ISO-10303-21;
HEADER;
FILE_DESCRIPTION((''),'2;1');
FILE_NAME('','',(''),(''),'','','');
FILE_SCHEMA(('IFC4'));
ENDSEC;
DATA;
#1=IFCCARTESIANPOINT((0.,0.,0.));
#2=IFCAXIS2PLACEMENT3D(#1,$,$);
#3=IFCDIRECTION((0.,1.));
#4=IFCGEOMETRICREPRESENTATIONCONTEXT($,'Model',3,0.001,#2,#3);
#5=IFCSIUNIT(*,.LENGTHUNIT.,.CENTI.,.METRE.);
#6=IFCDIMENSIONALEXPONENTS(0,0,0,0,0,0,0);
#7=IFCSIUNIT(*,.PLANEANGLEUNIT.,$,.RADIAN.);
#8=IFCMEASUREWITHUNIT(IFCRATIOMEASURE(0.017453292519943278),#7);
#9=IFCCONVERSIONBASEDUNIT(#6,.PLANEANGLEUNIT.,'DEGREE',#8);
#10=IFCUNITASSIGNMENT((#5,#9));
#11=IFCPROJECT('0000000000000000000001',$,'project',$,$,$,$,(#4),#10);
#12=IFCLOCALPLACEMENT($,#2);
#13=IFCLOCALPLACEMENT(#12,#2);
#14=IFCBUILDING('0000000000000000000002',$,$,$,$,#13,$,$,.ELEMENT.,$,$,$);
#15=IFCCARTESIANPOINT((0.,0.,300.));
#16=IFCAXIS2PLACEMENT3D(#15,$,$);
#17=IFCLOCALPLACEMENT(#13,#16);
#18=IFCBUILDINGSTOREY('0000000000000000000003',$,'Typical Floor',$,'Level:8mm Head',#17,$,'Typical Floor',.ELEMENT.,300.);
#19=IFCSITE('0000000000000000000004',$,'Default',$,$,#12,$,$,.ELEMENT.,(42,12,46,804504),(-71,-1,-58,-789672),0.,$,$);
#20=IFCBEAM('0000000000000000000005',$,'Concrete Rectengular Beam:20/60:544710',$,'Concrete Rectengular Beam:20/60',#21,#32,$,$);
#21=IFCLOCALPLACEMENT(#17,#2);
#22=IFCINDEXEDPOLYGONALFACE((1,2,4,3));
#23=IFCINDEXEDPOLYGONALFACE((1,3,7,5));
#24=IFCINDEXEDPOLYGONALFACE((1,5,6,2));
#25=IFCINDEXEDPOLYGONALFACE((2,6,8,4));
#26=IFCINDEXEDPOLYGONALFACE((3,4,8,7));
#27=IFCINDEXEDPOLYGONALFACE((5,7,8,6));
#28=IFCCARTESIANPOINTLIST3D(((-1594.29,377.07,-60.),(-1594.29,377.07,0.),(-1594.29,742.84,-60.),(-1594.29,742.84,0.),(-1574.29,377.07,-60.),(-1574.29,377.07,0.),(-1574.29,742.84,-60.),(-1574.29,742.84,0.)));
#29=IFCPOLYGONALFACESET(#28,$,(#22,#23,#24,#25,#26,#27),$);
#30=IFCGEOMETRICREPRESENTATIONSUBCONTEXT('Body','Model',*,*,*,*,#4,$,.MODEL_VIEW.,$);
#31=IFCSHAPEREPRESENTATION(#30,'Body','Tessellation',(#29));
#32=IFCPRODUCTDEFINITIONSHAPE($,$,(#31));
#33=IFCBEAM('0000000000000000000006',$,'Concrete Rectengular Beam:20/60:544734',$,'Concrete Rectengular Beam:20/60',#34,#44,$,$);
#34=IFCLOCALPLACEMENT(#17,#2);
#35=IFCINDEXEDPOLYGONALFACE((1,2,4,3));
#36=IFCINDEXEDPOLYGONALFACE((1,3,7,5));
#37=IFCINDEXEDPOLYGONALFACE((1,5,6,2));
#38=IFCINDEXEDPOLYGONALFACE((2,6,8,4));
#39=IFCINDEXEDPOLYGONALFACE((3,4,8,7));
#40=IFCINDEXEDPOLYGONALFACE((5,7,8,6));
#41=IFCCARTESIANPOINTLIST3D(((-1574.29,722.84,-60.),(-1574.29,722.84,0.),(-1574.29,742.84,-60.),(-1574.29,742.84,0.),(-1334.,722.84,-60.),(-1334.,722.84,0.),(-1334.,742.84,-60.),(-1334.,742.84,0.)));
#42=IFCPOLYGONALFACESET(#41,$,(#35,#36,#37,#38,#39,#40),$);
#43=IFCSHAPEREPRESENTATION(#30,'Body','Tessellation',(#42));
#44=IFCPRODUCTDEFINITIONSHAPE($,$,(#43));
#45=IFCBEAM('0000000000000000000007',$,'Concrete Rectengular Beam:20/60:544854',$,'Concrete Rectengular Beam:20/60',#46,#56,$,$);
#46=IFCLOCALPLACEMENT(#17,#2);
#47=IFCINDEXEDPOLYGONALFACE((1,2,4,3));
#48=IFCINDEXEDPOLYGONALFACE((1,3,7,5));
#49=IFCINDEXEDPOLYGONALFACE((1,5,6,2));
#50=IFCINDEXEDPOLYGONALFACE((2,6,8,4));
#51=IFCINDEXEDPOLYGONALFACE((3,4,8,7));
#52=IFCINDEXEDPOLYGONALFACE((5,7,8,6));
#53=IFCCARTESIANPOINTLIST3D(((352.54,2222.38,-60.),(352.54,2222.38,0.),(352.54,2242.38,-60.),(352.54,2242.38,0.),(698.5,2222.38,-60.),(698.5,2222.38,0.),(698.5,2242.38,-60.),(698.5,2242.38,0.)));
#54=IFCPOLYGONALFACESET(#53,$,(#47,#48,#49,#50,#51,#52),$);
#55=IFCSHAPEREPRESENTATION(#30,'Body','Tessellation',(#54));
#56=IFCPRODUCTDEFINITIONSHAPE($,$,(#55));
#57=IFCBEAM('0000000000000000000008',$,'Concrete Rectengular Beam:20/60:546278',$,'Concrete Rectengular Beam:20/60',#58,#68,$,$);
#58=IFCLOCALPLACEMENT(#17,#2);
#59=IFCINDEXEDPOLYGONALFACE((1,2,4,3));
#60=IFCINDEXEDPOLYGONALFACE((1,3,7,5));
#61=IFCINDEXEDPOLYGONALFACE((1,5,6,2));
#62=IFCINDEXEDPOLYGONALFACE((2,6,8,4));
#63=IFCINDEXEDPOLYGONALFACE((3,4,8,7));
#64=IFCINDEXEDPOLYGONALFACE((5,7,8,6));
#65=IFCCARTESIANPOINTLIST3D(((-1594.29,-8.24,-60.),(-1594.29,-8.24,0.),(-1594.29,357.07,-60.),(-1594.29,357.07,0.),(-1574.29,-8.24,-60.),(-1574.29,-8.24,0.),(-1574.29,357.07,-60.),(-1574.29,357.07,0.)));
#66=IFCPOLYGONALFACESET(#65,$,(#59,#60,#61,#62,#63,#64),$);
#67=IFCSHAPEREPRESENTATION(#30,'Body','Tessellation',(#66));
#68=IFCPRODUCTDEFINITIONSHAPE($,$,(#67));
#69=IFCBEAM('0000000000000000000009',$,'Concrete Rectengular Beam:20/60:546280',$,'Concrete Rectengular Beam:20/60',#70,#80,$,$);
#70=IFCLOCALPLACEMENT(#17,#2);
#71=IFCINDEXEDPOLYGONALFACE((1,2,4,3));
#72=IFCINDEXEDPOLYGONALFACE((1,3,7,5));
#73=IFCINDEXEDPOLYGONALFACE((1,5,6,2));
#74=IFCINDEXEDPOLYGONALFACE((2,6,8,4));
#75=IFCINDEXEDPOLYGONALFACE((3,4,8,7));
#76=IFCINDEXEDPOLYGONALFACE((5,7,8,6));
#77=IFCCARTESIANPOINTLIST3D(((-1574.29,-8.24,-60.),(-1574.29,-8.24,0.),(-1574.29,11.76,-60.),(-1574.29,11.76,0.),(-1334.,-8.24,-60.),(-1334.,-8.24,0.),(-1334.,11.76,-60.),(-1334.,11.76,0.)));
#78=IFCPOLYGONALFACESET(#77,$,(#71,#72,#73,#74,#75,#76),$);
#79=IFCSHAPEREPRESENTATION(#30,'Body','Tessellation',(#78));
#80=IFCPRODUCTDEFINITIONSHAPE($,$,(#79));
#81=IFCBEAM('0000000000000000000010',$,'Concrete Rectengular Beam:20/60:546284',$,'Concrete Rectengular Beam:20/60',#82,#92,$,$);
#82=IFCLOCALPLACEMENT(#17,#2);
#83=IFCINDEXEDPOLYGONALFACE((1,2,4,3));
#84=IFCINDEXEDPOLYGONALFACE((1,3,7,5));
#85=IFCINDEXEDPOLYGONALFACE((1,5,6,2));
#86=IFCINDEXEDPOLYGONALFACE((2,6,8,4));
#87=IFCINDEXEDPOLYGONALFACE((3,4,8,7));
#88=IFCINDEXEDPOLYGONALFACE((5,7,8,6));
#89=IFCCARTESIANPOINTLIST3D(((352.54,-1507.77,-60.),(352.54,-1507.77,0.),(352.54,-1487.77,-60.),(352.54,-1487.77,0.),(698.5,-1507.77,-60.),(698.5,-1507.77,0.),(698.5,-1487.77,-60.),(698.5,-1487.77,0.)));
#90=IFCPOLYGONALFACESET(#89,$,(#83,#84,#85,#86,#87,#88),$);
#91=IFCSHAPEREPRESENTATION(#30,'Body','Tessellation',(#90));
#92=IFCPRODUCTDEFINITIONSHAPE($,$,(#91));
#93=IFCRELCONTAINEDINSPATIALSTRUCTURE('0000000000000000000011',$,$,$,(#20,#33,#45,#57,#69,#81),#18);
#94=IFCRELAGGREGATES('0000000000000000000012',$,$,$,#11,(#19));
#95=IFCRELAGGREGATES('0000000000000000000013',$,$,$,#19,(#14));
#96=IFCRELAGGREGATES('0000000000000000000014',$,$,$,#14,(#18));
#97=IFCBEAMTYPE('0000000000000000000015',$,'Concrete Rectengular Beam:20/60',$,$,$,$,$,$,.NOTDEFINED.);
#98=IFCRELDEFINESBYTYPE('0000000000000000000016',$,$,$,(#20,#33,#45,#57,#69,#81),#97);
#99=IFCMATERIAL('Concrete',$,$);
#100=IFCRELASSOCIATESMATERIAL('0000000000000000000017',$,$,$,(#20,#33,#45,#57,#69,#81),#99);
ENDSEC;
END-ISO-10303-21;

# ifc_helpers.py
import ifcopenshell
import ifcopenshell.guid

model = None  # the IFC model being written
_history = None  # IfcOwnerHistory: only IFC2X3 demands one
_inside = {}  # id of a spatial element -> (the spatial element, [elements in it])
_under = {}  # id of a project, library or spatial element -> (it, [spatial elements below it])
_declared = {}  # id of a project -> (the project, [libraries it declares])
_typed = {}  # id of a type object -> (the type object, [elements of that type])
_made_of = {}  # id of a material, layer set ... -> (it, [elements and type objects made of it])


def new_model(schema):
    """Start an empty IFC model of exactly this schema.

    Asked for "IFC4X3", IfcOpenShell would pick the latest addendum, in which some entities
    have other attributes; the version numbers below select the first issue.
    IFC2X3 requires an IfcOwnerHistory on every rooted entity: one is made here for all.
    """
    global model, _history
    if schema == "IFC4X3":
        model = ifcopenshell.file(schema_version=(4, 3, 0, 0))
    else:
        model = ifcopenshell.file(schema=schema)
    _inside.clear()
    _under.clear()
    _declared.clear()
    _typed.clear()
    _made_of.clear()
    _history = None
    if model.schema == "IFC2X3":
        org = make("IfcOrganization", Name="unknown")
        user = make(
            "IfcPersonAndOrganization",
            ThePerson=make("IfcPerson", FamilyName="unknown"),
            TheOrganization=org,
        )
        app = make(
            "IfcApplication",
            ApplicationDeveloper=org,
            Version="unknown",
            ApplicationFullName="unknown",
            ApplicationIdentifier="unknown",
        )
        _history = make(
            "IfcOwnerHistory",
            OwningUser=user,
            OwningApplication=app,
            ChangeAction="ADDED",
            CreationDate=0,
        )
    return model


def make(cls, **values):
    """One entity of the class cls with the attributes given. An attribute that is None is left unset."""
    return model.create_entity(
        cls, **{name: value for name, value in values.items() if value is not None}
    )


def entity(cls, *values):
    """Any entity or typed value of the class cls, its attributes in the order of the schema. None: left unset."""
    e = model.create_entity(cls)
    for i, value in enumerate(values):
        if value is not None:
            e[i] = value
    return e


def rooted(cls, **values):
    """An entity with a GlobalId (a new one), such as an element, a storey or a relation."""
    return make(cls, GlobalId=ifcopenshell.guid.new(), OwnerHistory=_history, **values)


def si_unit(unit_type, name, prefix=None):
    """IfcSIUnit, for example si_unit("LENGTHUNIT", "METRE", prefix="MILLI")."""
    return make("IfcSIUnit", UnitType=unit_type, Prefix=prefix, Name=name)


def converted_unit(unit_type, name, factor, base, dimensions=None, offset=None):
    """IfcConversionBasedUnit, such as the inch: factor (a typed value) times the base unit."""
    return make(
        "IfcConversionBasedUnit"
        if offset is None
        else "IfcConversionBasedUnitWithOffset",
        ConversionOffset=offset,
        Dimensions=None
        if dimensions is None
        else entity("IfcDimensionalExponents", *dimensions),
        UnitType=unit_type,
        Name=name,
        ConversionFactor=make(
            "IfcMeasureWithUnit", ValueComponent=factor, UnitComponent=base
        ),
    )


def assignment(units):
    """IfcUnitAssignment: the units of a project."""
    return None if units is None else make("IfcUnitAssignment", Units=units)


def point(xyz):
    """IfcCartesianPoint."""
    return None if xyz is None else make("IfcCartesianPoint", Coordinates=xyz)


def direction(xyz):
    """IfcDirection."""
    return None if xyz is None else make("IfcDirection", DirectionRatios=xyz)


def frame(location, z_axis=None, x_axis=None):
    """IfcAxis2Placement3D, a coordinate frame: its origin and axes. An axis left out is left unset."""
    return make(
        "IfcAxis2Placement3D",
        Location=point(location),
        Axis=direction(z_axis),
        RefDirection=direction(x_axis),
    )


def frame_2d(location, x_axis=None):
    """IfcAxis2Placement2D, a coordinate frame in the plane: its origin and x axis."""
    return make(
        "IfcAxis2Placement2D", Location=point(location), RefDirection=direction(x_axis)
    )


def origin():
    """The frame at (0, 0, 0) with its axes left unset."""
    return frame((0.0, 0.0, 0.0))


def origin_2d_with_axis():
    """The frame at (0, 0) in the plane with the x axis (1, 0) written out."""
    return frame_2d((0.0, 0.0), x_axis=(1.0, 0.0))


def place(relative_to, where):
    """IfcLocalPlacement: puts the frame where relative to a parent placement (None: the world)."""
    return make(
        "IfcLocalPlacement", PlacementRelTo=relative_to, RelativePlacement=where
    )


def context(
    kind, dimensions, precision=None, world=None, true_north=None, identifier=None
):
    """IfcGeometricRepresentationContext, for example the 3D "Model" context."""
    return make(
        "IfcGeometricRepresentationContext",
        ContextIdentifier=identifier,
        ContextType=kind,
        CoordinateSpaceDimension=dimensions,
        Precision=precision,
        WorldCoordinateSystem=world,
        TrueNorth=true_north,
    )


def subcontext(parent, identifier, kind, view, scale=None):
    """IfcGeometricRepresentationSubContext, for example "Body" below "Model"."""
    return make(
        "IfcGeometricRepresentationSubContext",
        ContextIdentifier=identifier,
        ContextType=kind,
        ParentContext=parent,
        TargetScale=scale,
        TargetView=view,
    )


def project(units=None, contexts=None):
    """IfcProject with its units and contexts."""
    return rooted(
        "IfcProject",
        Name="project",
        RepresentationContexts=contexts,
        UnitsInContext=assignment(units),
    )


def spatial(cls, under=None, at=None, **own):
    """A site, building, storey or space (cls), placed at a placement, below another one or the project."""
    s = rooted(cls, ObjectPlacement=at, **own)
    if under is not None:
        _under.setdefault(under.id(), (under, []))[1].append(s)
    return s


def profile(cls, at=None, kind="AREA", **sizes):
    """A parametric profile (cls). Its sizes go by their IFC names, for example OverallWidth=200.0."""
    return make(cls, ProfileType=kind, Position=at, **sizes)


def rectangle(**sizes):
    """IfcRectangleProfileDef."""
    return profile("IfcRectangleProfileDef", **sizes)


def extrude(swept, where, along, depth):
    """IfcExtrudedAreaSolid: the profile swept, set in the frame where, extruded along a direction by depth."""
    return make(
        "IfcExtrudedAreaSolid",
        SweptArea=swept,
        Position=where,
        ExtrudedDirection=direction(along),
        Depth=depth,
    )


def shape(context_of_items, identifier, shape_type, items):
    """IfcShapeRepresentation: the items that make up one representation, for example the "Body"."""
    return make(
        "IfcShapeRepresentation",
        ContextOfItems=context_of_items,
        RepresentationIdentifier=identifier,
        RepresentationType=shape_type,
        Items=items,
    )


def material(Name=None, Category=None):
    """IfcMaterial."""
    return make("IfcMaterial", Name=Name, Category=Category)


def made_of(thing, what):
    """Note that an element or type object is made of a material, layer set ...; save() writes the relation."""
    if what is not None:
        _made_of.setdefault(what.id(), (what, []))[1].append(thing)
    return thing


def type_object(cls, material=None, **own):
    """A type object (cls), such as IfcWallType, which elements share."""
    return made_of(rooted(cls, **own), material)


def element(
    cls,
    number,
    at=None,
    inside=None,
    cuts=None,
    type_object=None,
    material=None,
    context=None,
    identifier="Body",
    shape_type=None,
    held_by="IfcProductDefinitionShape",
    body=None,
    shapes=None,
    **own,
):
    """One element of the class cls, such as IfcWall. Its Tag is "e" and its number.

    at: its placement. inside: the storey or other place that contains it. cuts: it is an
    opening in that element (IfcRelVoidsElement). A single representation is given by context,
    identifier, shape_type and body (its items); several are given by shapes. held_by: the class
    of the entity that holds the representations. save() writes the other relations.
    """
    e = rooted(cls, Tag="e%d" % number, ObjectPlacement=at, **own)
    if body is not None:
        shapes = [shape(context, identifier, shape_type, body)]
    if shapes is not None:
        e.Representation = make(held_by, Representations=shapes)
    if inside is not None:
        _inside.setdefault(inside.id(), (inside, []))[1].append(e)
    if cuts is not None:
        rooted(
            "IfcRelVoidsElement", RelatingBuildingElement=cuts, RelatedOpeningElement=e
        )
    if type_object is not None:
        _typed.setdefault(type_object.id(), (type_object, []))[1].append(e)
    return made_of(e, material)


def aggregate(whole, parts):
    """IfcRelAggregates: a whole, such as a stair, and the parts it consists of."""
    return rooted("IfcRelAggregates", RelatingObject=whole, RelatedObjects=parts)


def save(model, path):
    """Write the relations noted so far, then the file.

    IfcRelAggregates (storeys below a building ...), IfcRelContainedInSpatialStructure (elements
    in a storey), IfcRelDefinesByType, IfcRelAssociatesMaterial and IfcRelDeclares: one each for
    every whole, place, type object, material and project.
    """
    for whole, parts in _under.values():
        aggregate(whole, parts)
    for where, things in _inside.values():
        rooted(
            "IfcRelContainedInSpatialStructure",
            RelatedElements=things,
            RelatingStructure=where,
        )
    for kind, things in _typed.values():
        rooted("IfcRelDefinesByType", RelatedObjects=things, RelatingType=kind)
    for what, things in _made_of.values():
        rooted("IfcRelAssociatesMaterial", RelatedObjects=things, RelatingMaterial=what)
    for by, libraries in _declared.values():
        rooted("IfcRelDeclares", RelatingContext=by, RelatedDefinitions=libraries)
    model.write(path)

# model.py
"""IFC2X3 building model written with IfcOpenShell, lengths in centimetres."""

from ifc_helpers import new_model, entity, si_unit, converted_unit, direction, frame, frame_2d, origin, origin_2d_with_axis, place, context, subcontext, project, spatial, rectangle, extrude, material, type_object, element, save


model = new_model("IFC2X3")

# Units and contexts
model_context = context("Model", 3, precision=0.001, world=origin(), true_north=direction((0.0, 1.0)))
body_context = subcontext(model_context, "Body", "Model", "MODEL_VIEW")
ifc_project = project(units=[si_unit("LENGTHUNIT", "METRE", prefix="CENTI"), converted_unit("PLANEANGLEUNIT", "DEGREE", entity("IfcRatioMeasure", 0.017453292519943278), si_unit("PLANEANGLEUNIT", "RADIAN"), dimensions=[0, 0, 0, 0, 0, 0, 0])], contexts=[model_context])

# Site, building, storey
site_placement = place(None, origin())
site = spatial("IfcSite", under=ifc_project, at=site_placement, Name="Default", CompositionType="ELEMENT", RefLatitude=(42, 12, 46, 804504), RefLongitude=(-71, -1, -58, -789672), RefElevation=0.0)
building_placement = place(site_placement, origin())
building = spatial("IfcBuilding", under=site, at=building_placement, CompositionType="ELEMENT")
storey_placement = place(building_placement, frame((0.0, 0.0, 300.0)))
storey = spatial("IfcBuildingStorey", under=building, at=storey_placement, Name="Typical Floor", ObjectType="Level:8mm Head", LongName="Typical Floor", CompositionType="ELEMENT", Elevation=300.0)

# Beams
ifc_material = material(Name="Concrete")
beam_type = type_object("IfcBeamType", Name="Concrete Rectengular Beam:20/60", PredefinedType="NOTDEFINED")
beam_1_placement = place(storey_placement, frame((-1584.29, 367.07, 0.0), z_axis=(0.0, 0.0, 1.0), x_axis=(0.0, 1.0, 0.0)))
element("IfcBeam", 1, at=beam_1_placement, inside=storey, type_object=beam_type, material=ifc_material, Name="Concrete Rectengular Beam:20/60:544710", ObjectType="Concrete Rectengular Beam:20/60", context=body_context, shape_type="SweptSolid", body=[
    extrude(rectangle(XDim=60.0, YDim=20.0, at=frame_2d((0.0, 0.0), x_axis=(1.0, 0.0))), frame((10.0, 0.0, -30.0), z_axis=(1.0, 0.0, 0.0), x_axis=(0.0, 0.0, -1.0)), (0.0, 0.0, 1.0), 365.78),
])
beam_2_placement = place(storey_placement, frame((-1584.29, 732.84, 0.0)))
element("IfcBeam", 2, at=beam_2_placement, inside=storey, type_object=beam_type, material=ifc_material, Name="Concrete Rectengular Beam:20/60:544734", ObjectType="Concrete Rectengular Beam:20/60", context=body_context, shape_type="SweptSolid", body=[
    extrude(rectangle(XDim=60.0, YDim=20.0, at=frame_2d((0.0, 0.0), x_axis=(1.0, 0.0))), frame((10.0, 0.0, -30.0), z_axis=(1.0, 0.0, 0.0), x_axis=(0.0, 0.0, -1.0)), (0.0, 0.0, 1.0), 240.29),
])
beam_3_placement = place(storey_placement, frame((342.54, 2232.38, 0.0)))
element("IfcBeam", 3, at=beam_3_placement, inside=storey, type_object=beam_type, material=ifc_material, Name="Concrete Rectengular Beam:20/60:544854", ObjectType="Concrete Rectengular Beam:20/60", context=body_context, shape_type="SweptSolid", body=[
    extrude(rectangle(XDim=60.0, YDim=20.0, at=frame_2d((0.0, 0.0), x_axis=(1.0, 0.0))), frame((10.0, 0.0, -30.0), z_axis=(1.0, 0.0, 0.0), x_axis=(0.0, 0.0, -1.0)), (0.0, 0.0, 1.0), 345.97),
])
beam_4_placement = place(storey_placement, frame((-1584.29, 367.07, 0.0), z_axis=(0.0, 0.0, 1.0), x_axis=(0.0, -1.0, 0.0)))
element("IfcBeam", 4, at=beam_4_placement, inside=storey, type_object=beam_type, material=ifc_material, Name="Concrete Rectengular Beam:20/60:546278", ObjectType="Concrete Rectengular Beam:20/60", context=body_context, shape_type="SweptSolid", body=[
    extrude(rectangle(XDim=60.0, YDim=20.0, at=origin_2d_with_axis()), frame((10.0, 0.0, -30.0), z_axis=(1.0, 0.0, 0.0), x_axis=(0.0, 0.0, -1.0)), (0.0, 0.0, 1.0), 365.3),
])
beam_5_placement = place(storey_placement, frame((-1584.29, 1.76, 0.0)))
element("IfcBeam", 5, at=beam_5_placement, inside=storey, type_object=beam_type, material=ifc_material, Name="Concrete Rectengular Beam:20/60:546280", ObjectType="Concrete Rectengular Beam:20/60", context=body_context, shape_type="SweptSolid", body=[
    extrude(rectangle(XDim=60.0, YDim=20.0, at=frame_2d((0.0, 0.0), x_axis=(1.0, 0.0))), frame((10.0, 0.0, -30.0), z_axis=(1.0, 0.0, 0.0), x_axis=(0.0, 0.0, -1.0)), (0.0, 0.0, 1.0), 240.29),
])
beam_6_placement = place(storey_placement, frame((342.54, -1497.77, 0.0)))
element("IfcBeam", 6, at=beam_6_placement, inside=storey, type_object=beam_type, material=ifc_material, Name="Concrete Rectengular Beam:20/60:546284", ObjectType="Concrete Rectengular Beam:20/60", context=body_context, shape_type="SweptSolid", body=[
    extrude(rectangle(XDim=60.0, YDim=20.0, at=frame_2d((0.0, 0.0), x_axis=(1.0, 0.0))), frame((10.0, 0.0, -30.0), z_axis=(1.0, 0.0, 0.0), x_axis=(0.0, 0.0, -1.0)), (0.0, 0.0, 1.0), 345.97),
])

save(model, "model.ifc")
